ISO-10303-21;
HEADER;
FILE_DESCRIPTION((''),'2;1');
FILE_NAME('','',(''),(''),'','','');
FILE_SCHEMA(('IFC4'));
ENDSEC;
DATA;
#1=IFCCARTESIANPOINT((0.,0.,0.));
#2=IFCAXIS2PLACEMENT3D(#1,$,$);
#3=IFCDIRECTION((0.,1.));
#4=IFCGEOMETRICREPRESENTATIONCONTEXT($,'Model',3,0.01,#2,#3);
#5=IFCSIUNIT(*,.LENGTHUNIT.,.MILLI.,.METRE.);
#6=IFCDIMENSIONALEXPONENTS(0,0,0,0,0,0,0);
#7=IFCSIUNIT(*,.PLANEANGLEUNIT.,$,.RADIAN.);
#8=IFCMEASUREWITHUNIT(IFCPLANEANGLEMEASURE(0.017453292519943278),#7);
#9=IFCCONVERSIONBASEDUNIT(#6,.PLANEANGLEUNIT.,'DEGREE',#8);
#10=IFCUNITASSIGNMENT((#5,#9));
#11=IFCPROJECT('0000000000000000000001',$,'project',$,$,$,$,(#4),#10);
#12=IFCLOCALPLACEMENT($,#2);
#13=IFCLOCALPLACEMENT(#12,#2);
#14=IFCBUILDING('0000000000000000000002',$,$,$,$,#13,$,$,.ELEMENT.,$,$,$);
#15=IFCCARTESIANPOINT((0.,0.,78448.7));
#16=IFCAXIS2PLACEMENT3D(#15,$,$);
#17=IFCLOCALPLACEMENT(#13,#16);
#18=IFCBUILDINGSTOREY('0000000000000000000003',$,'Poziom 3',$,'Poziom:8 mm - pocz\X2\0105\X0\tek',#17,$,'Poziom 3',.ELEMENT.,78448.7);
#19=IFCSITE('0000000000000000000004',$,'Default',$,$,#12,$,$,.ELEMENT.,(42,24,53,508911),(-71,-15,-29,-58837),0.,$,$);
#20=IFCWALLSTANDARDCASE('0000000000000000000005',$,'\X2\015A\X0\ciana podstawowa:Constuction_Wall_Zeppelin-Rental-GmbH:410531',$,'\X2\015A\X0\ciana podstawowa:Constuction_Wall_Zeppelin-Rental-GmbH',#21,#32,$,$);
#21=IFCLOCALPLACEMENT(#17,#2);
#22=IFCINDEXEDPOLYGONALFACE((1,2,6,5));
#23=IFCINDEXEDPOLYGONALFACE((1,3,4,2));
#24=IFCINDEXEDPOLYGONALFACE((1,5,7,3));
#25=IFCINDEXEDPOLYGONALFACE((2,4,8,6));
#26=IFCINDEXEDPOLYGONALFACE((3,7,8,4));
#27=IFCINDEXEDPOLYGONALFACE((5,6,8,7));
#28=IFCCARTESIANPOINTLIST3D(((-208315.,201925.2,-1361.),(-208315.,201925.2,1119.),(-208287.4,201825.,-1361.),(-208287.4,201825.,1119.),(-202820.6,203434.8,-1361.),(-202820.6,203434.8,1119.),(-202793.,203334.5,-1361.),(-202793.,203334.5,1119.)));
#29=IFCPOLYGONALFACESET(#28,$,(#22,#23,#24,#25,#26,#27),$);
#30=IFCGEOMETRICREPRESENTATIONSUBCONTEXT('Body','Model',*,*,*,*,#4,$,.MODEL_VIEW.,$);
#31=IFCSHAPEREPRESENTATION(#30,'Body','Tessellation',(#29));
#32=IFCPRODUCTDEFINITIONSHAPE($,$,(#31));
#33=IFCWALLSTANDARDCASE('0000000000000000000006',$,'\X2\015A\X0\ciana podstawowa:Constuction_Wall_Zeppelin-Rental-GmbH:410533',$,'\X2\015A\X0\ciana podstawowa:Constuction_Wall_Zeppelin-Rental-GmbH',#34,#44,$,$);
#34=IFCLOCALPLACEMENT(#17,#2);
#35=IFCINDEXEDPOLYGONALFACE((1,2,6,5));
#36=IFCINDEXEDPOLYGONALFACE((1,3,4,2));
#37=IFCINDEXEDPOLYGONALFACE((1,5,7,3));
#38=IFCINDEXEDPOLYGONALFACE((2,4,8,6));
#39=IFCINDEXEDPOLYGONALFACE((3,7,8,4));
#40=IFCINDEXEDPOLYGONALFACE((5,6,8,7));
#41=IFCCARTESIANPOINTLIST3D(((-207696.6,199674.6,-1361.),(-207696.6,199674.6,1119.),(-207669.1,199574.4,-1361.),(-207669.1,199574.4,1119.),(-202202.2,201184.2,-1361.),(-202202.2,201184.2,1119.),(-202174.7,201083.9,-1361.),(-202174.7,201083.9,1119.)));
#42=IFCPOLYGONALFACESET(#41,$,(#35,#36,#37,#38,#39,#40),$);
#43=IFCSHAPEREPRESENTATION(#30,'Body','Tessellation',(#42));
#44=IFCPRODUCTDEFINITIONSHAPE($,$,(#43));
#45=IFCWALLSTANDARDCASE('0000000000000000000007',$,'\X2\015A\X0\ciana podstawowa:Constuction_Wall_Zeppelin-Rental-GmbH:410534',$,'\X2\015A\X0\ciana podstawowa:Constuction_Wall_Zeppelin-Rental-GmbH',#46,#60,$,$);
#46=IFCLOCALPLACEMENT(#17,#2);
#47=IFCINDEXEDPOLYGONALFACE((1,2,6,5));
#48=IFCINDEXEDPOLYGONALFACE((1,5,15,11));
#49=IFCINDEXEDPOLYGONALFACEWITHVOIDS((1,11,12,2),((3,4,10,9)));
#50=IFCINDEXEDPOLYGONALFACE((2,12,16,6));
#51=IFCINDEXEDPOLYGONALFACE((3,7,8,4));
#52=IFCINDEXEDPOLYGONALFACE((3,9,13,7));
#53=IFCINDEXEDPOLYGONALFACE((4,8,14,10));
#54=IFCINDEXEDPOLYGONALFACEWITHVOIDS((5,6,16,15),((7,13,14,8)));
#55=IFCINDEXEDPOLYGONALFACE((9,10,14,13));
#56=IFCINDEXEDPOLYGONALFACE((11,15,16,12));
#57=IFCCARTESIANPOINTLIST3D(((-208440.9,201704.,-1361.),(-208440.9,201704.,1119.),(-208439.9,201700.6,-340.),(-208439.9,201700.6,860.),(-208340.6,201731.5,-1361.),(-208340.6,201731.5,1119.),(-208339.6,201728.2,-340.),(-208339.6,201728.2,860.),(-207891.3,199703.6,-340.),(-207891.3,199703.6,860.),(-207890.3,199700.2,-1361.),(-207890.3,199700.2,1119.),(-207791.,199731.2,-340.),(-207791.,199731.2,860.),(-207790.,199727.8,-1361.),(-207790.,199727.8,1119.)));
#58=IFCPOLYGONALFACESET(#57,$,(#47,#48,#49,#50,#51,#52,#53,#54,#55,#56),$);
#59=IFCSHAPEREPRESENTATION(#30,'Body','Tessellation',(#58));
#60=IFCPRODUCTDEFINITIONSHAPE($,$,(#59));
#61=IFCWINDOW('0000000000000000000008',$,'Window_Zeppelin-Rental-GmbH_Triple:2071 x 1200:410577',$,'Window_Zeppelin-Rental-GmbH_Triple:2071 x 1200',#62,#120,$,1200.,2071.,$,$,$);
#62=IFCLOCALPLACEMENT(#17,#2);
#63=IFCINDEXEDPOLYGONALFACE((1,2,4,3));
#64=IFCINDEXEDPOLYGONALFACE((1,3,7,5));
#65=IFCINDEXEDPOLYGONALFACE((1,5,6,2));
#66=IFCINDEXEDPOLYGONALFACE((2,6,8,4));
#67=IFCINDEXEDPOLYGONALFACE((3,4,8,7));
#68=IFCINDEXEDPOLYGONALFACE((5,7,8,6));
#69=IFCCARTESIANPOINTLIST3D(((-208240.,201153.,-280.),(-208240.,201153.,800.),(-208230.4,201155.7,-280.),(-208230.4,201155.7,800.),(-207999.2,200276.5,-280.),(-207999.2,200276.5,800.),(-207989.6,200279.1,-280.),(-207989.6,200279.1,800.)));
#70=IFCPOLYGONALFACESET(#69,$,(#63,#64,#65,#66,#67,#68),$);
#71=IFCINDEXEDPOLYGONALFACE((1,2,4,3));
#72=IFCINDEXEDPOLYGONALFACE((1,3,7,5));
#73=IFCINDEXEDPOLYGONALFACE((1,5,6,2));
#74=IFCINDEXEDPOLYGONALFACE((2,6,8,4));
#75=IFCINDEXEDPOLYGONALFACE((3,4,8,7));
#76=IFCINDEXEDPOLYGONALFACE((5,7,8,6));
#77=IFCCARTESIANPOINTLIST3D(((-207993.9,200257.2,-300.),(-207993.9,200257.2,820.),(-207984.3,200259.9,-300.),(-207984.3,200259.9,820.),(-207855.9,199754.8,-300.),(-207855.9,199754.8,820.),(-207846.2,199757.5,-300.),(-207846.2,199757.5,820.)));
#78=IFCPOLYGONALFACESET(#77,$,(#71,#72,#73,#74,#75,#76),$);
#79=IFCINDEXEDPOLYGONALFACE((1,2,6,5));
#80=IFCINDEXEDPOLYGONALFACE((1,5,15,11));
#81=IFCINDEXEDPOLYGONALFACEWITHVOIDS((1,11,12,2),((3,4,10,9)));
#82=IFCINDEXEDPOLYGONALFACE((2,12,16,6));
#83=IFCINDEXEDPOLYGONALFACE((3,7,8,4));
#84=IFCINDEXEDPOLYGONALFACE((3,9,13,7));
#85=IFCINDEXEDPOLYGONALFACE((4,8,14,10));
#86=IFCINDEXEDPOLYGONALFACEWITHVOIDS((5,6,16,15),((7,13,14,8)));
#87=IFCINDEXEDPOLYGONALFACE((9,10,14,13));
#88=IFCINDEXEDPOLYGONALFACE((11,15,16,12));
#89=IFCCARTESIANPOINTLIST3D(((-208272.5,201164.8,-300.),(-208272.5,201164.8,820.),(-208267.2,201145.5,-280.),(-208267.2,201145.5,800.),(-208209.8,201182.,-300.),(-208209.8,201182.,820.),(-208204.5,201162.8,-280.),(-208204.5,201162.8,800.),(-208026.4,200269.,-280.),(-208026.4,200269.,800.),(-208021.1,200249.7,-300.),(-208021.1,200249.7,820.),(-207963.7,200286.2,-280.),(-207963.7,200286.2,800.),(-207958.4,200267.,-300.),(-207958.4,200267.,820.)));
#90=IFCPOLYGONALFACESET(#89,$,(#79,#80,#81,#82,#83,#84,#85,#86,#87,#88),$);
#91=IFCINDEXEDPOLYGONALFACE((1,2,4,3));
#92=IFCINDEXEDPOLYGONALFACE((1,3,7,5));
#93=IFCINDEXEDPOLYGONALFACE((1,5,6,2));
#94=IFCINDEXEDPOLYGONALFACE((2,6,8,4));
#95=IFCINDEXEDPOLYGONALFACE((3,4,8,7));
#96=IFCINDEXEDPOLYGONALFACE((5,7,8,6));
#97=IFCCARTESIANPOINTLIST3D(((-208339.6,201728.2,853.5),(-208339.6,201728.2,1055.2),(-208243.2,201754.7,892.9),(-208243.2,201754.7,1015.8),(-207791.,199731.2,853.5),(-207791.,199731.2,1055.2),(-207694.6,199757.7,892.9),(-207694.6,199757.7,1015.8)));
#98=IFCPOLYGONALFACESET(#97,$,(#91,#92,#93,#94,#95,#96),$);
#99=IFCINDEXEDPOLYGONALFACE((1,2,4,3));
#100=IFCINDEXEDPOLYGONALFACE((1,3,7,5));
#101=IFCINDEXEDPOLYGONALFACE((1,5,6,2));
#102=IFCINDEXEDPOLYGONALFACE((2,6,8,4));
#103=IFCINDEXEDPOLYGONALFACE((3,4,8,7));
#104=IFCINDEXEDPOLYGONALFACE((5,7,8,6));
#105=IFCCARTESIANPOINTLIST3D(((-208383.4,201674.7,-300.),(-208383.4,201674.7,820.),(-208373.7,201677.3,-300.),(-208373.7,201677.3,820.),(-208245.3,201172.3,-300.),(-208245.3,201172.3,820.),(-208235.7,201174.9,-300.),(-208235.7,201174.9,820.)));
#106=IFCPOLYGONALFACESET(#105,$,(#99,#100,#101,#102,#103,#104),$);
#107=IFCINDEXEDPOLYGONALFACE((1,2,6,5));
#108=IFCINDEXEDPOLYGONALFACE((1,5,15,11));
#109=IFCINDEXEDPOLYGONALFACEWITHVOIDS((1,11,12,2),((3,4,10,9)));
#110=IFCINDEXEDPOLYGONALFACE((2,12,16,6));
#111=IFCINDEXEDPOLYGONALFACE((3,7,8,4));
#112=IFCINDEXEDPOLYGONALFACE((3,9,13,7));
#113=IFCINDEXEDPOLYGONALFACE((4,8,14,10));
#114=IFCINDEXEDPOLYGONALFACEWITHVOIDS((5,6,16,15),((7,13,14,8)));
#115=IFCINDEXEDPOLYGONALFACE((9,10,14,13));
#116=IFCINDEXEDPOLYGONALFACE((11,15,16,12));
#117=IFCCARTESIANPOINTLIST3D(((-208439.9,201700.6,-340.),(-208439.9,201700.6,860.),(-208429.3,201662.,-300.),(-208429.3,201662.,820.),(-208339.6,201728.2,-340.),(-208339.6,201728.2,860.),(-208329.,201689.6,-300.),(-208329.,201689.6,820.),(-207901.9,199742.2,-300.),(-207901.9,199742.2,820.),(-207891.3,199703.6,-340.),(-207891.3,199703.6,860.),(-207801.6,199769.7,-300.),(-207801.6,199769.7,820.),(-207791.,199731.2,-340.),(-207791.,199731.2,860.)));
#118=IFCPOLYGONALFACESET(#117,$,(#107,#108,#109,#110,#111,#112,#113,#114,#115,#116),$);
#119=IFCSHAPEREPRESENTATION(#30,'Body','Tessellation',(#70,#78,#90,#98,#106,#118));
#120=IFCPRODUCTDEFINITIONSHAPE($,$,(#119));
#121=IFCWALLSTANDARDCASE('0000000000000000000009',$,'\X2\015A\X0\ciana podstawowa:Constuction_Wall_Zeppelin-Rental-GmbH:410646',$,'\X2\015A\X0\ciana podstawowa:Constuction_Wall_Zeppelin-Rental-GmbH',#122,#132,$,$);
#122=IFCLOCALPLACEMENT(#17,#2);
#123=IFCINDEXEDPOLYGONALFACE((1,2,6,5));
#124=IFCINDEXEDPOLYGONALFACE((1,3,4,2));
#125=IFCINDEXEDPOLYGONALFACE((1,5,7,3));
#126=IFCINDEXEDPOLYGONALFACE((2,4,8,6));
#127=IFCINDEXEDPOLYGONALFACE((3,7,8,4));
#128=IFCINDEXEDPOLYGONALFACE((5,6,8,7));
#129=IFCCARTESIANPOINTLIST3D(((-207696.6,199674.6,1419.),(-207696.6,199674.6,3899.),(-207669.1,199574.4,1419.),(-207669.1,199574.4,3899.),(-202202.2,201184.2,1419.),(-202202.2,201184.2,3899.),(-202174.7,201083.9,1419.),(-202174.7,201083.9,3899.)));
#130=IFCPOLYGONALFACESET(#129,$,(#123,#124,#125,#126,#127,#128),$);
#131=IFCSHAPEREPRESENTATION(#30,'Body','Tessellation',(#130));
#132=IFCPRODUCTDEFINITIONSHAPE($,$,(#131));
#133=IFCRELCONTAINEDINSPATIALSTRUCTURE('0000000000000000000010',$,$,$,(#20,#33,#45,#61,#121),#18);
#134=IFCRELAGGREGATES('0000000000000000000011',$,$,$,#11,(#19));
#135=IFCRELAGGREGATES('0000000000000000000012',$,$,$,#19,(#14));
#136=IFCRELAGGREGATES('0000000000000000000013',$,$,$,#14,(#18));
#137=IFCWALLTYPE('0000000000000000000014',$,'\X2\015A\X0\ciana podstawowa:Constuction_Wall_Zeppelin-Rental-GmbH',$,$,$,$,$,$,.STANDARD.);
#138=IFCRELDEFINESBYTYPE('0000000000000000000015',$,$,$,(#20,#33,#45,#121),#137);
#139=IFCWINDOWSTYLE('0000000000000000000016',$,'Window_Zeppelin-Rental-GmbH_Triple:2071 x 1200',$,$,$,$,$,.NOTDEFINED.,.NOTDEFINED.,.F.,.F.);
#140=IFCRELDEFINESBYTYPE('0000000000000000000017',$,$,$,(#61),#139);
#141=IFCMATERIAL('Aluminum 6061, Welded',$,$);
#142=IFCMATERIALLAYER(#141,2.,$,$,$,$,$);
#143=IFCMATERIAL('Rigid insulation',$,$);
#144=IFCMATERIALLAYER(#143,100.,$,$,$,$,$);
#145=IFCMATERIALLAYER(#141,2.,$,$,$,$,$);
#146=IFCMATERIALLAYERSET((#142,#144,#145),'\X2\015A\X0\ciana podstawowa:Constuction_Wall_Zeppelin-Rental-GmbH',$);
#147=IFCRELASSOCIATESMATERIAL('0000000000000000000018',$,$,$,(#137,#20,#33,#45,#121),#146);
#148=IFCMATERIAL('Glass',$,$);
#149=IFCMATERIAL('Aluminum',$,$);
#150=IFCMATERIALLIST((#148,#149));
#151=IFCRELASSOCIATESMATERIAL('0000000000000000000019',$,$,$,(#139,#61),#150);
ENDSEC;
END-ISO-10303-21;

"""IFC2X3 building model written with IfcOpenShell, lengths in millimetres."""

from ifc_helpers import new_model, entity, si_unit, converted_unit, direction, frame, frame_2d, origin, origin_2d_with_axis, place, context, subcontext, project, spatial, polyline, rectangle, outline, extrude, source, transform, mapped, material, material_list, layer, layer_set, layer_usage, type_object, type_shapes, element, fill, save


model = new_model("IFC2X3")

# Units and contexts
model_context = context("Model", 3, precision=0.01, world=origin(), true_north=direction((0.0, 1.0)))
body_context = subcontext(model_context, "Body", "Model", "MODEL_VIEW")
ifc_project = project(units=[si_unit("LENGTHUNIT", "METRE", prefix="MILLI"), converted_unit("PLANEANGLEUNIT", "DEGREE", entity("IfcPlaneAngleMeasure", 0.017453292519943278), si_unit("PLANEANGLEUNIT", "RADIAN"), dimensions=[0, 0, 0, 0, 0, 0, 0])], contexts=[model_context])

# Site, building, storey
site_placement = place(None, origin())
site = spatial("IfcSite", under=ifc_project, at=site_placement, Name="Default", CompositionType="ELEMENT", RefLatitude=(42, 24, 53, 508911), RefLongitude=(-71, -15, -29, -58837), RefElevation=0.0)
building_placement = place(site_placement, origin())
building = spatial("IfcBuilding", under=site, at=building_placement, CompositionType="ELEMENT")
storey_placement = place(building_placement, frame((0.0, 0.0, 78448.7)))
storey = spatial("IfcBuildingStorey", under=building, at=storey_placement, Name="Poziom 3", ObjectType="Poziom:8 mm - początek", LongName="Poziom 3", CompositionType="ELEMENT", Elevation=78448.7)

# Walls
ifc_material_1 = material(Name="Aluminum 6061, Welded")
ifc_layer_1 = layer(ifc_material_1, 2.0)
ifc_material_2 = material(Name="Rigid insulation")
ifc_layer_2 = layer(ifc_material_2, 100.0)
ifc_layer_3 = layer(ifc_material_1, 2.0)
ifc_layer_set = layer_set([ifc_layer_1, ifc_layer_2, ifc_layer_3], Name="Ściana podstawowa:Constuction_Wall_Zeppelin-Rental-GmbH")
ifc_layer_usage_1 = layer_usage(ifc_layer_set, "AXIS2", "NEGATIVE", 52.0)
wall_type_1 = type_object("IfcWallType", Name="Ściana podstawowa:Constuction_Wall_Zeppelin-Rental-GmbH", PredefinedType="STANDARD", material=ifc_layer_set)
wall_1_placement = place(storey_placement, frame((-208301.2, 201875.1, -1361.0), z_axis=(0.0, 0.0, 1.0), x_axis=(0.964267, 0.264931, 0.0)))
element("IfcWallStandardCase", 1, at=wall_1_placement, inside=storey, type_object=wall_type_1, material=ifc_layer_usage_1, Name="Ściana podstawowa:Constuction_Wall_Zeppelin-Rental-GmbH:410531", ObjectType="Ściana podstawowa:Constuction_Wall_Zeppelin-Rental-GmbH", context=body_context, shape_type="SweptSolid", body=[
    extrude(rectangle(XDim=5698.0, YDim=104.0, at=frame_2d((2849.0, 0.0), x_axis=(-1.0, 0.0))), origin(), (0.0, 0.0, 1.0), 2480.0),
])
ifc_layer_usage_2 = layer_usage(ifc_layer_set, "AXIS2", "NEGATIVE", 52.0)
wall_2_placement = place(storey_placement, frame((-202188.5, 201134.1, -1361.0), z_axis=(0.0, 0.0, 1.0), x_axis=(-0.964267, -0.264931, 0.0)))
element("IfcWallStandardCase", 2, at=wall_2_placement, inside=storey, type_object=wall_type_1, material=ifc_layer_usage_2, Name="Ściana podstawowa:Constuction_Wall_Zeppelin-Rental-GmbH:410533", ObjectType="Ściana podstawowa:Constuction_Wall_Zeppelin-Rental-GmbH", context=body_context, shape_type="SweptSolid", body=[
    extrude(rectangle(XDim=5698.0, YDim=104.0, at=frame_2d((2849.0, 0.0), x_axis=(-1.0, 0.0))), origin(), (0.0, 0.0, 1.0), 2480.0),
])

# Wall, opening, window
ifc_layer_usage_3 = layer_usage(ifc_layer_set, "AXIS2", "NEGATIVE", 52.0)
wall_3_placement = place(storey_placement, frame((-207840.2, 199714.0, -1361.0), z_axis=(0.0, 0.0, 1.0), x_axis=(-0.264931, 0.964267, 0.0)))
wall_3 = element("IfcWallStandardCase", 3, at=wall_3_placement, inside=storey, type_object=wall_type_1, material=ifc_layer_usage_3, Name="Ściana podstawowa:Constuction_Wall_Zeppelin-Rental-GmbH:410534", ObjectType="Ściana podstawowa:Constuction_Wall_Zeppelin-Rental-GmbH", context=body_context, shape_type="SweptSolid", body=[
    extrude(rectangle(XDim=2078.0, YDim=104.0, at=frame_2d((1039.0, 0.0), x_axis=(-1.0, 0.0))), origin(), (0.0, 0.0, 1.0), 2480.0),
])
opening_1_placement = place(wall_3_placement, frame((3.5, -52.0, 1021.0)))
opening_1 = element("IfcOpeningElement", 4, at=opening_1_placement, cuts=wall_3, ObjectType="Opening", context=body_context, shape_type="SweptSolid", body=[
    extrude(rectangle(XDim=1200.0, YDim=2071.0, at=frame_2d((600.0, 1035.5), x_axis=(1.0, 0.0))), frame((0.0, 0.0, 0.0), z_axis=(0.0, 1.0, 0.0), x_axis=(0.0, 0.0, 1.0)), (0.0, 0.0, 1.0), 104.0),
])
ifc_material_3 = material(Name="Glass")
ifc_material_4 = material(Name="Aluminum")
ifc_material_list = material_list([ifc_material_3, ifc_material_4])
window_style = type_object("IfcWindowStyle", Name="Window_Zeppelin-Rental-GmbH_Triple:2071 x 1200", ConstructionType="NOTDEFINED", OperationType="NOTDEFINED", ParameterTakesPrecedence=False, Sizeable=False, material=ifc_material_list)
shared_shape_1 = source(origin(), body_context, "Body", "SweptSolid", [
    extrude(rectangle(XDim=10.0, YDim=909.0, at=origin_2d_with_axis()), frame((1035.5, 52.7, 60.0), z_axis=(0.0, 0.0, 1.0), x_axis=(0.0, -1.0, 0.0)), (0.0, 0.0, 1.0), 1080.0),
    extrude(rectangle(XDim=521.0, YDim=10.0, at=frame_2d((0.0, 0.0), x_axis=(1.0, 0.0))), frame((300.5, 52.7, 40.0), z_axis=(0.0, 0.0, 1.0), x_axis=(-1.0, 0.0, 0.0)), (0.0, 0.0, 1.0), 1120.0),
    extrude(outline(polyline([(-474.5, -560.0), (474.5, -560.0), (474.5, 560.0), (-474.5, 560.0), (-474.5, -560.0)]), holes=[polyline([(-454.5, 540.0), (454.5, 540.0), (454.5, -540.0), (-454.5, -540.0), (-454.5, 540.0)])]), frame((1035.5, 85.8, 600.0), z_axis=(0.0, -1.0, 0.0), x_axis=(1.0, 0.0, 0.0)), (0.0, 0.0, 1.0), 65.0),
    extrude(outline(polyline([(-24.0, -75.5), (83.5, -75.5), (9.6, 112.1), (-69.0, 38.9), (-24.0, -75.5)])), frame((2071.0, -48.7, 1294.4), z_axis=(-1.0, 0.0, 0.0), x_axis=(0.0, 0.930458, 0.366398)), (0.0, 0.0, 1.0), 2071.0),
    extrude(rectangle(XDim=10.0, YDim=521.0, at=frame_2d((0.0, 0.0), x_axis=(1.0, 0.0))), frame((1770.5, 52.7, 40.0), z_axis=(0.0, 0.0, 1.0), x_axis=(0.0, -1.0, 0.0)), (0.0, 0.0, 1.0), 1120.0),
    extrude(outline(polyline([(-1035.5, -600.0), (1035.5, -600.0), (1035.5, 600.0), (-1035.5, 600.0), (-1035.5, -600.0)]), holes=[polyline([(-995.5, 560.0), (995.5, 560.0), (995.5, -560.0), (-995.5, -560.0), (-995.5, 560.0)])]), frame((1035.5, 105.3, 600.0), z_axis=(0.0, -1.0, 0.0), x_axis=(1.0, 0.0, 0.0)), (0.0, 0.0, 1.0), 104.0),
])
type_shapes(window_style, [shared_shape_1])
window_1_placement = place(opening_1_placement, frame((0.0, -1.3, 0.0)))
window_1 = element("IfcWindow", 5, at=window_1_placement, inside=storey, type_object=window_style, material=ifc_material_list, Name="Window_Zeppelin-Rental-GmbH_Triple:2071 x 1200:410577", ObjectType="Window_Zeppelin-Rental-GmbH_Triple:2071 x 1200", OverallHeight=1200.0, OverallWidth=2071.0, context=body_context, shape_type="MappedRepresentation", body=[
    mapped(shared_shape_1, transform((0.0, 0.0, 0.0), scale=1.0)),
])
fill(opening_1, window_1)

# Wall
ifc_layer_usage_4 = layer_usage(ifc_layer_set, "AXIS2", "NEGATIVE", 52.0)
wall_4_placement = place(storey_placement, frame((-202188.5, 201134.1, 1419.0), z_axis=(0.0, 0.0, 1.0), x_axis=(-0.964267, -0.264931, 0.0)))
element("IfcWallStandardCase", 6, at=wall_4_placement, inside=storey, type_object=wall_type_1, material=ifc_layer_usage_4, Name="Ściana podstawowa:Constuction_Wall_Zeppelin-Rental-GmbH:410646", ObjectType="Ściana podstawowa:Constuction_Wall_Zeppelin-Rental-GmbH", context=body_context, shape_type="SweptSolid", body=[
    extrude(rectangle(XDim=5698.0, YDim=104.0, at=frame_2d((2849.0, 0.0), x_axis=(-1.0, 0.0))), origin(), (0.0, 0.0, 1.0), 2480.0),
])

save(model, "model.ifc")
